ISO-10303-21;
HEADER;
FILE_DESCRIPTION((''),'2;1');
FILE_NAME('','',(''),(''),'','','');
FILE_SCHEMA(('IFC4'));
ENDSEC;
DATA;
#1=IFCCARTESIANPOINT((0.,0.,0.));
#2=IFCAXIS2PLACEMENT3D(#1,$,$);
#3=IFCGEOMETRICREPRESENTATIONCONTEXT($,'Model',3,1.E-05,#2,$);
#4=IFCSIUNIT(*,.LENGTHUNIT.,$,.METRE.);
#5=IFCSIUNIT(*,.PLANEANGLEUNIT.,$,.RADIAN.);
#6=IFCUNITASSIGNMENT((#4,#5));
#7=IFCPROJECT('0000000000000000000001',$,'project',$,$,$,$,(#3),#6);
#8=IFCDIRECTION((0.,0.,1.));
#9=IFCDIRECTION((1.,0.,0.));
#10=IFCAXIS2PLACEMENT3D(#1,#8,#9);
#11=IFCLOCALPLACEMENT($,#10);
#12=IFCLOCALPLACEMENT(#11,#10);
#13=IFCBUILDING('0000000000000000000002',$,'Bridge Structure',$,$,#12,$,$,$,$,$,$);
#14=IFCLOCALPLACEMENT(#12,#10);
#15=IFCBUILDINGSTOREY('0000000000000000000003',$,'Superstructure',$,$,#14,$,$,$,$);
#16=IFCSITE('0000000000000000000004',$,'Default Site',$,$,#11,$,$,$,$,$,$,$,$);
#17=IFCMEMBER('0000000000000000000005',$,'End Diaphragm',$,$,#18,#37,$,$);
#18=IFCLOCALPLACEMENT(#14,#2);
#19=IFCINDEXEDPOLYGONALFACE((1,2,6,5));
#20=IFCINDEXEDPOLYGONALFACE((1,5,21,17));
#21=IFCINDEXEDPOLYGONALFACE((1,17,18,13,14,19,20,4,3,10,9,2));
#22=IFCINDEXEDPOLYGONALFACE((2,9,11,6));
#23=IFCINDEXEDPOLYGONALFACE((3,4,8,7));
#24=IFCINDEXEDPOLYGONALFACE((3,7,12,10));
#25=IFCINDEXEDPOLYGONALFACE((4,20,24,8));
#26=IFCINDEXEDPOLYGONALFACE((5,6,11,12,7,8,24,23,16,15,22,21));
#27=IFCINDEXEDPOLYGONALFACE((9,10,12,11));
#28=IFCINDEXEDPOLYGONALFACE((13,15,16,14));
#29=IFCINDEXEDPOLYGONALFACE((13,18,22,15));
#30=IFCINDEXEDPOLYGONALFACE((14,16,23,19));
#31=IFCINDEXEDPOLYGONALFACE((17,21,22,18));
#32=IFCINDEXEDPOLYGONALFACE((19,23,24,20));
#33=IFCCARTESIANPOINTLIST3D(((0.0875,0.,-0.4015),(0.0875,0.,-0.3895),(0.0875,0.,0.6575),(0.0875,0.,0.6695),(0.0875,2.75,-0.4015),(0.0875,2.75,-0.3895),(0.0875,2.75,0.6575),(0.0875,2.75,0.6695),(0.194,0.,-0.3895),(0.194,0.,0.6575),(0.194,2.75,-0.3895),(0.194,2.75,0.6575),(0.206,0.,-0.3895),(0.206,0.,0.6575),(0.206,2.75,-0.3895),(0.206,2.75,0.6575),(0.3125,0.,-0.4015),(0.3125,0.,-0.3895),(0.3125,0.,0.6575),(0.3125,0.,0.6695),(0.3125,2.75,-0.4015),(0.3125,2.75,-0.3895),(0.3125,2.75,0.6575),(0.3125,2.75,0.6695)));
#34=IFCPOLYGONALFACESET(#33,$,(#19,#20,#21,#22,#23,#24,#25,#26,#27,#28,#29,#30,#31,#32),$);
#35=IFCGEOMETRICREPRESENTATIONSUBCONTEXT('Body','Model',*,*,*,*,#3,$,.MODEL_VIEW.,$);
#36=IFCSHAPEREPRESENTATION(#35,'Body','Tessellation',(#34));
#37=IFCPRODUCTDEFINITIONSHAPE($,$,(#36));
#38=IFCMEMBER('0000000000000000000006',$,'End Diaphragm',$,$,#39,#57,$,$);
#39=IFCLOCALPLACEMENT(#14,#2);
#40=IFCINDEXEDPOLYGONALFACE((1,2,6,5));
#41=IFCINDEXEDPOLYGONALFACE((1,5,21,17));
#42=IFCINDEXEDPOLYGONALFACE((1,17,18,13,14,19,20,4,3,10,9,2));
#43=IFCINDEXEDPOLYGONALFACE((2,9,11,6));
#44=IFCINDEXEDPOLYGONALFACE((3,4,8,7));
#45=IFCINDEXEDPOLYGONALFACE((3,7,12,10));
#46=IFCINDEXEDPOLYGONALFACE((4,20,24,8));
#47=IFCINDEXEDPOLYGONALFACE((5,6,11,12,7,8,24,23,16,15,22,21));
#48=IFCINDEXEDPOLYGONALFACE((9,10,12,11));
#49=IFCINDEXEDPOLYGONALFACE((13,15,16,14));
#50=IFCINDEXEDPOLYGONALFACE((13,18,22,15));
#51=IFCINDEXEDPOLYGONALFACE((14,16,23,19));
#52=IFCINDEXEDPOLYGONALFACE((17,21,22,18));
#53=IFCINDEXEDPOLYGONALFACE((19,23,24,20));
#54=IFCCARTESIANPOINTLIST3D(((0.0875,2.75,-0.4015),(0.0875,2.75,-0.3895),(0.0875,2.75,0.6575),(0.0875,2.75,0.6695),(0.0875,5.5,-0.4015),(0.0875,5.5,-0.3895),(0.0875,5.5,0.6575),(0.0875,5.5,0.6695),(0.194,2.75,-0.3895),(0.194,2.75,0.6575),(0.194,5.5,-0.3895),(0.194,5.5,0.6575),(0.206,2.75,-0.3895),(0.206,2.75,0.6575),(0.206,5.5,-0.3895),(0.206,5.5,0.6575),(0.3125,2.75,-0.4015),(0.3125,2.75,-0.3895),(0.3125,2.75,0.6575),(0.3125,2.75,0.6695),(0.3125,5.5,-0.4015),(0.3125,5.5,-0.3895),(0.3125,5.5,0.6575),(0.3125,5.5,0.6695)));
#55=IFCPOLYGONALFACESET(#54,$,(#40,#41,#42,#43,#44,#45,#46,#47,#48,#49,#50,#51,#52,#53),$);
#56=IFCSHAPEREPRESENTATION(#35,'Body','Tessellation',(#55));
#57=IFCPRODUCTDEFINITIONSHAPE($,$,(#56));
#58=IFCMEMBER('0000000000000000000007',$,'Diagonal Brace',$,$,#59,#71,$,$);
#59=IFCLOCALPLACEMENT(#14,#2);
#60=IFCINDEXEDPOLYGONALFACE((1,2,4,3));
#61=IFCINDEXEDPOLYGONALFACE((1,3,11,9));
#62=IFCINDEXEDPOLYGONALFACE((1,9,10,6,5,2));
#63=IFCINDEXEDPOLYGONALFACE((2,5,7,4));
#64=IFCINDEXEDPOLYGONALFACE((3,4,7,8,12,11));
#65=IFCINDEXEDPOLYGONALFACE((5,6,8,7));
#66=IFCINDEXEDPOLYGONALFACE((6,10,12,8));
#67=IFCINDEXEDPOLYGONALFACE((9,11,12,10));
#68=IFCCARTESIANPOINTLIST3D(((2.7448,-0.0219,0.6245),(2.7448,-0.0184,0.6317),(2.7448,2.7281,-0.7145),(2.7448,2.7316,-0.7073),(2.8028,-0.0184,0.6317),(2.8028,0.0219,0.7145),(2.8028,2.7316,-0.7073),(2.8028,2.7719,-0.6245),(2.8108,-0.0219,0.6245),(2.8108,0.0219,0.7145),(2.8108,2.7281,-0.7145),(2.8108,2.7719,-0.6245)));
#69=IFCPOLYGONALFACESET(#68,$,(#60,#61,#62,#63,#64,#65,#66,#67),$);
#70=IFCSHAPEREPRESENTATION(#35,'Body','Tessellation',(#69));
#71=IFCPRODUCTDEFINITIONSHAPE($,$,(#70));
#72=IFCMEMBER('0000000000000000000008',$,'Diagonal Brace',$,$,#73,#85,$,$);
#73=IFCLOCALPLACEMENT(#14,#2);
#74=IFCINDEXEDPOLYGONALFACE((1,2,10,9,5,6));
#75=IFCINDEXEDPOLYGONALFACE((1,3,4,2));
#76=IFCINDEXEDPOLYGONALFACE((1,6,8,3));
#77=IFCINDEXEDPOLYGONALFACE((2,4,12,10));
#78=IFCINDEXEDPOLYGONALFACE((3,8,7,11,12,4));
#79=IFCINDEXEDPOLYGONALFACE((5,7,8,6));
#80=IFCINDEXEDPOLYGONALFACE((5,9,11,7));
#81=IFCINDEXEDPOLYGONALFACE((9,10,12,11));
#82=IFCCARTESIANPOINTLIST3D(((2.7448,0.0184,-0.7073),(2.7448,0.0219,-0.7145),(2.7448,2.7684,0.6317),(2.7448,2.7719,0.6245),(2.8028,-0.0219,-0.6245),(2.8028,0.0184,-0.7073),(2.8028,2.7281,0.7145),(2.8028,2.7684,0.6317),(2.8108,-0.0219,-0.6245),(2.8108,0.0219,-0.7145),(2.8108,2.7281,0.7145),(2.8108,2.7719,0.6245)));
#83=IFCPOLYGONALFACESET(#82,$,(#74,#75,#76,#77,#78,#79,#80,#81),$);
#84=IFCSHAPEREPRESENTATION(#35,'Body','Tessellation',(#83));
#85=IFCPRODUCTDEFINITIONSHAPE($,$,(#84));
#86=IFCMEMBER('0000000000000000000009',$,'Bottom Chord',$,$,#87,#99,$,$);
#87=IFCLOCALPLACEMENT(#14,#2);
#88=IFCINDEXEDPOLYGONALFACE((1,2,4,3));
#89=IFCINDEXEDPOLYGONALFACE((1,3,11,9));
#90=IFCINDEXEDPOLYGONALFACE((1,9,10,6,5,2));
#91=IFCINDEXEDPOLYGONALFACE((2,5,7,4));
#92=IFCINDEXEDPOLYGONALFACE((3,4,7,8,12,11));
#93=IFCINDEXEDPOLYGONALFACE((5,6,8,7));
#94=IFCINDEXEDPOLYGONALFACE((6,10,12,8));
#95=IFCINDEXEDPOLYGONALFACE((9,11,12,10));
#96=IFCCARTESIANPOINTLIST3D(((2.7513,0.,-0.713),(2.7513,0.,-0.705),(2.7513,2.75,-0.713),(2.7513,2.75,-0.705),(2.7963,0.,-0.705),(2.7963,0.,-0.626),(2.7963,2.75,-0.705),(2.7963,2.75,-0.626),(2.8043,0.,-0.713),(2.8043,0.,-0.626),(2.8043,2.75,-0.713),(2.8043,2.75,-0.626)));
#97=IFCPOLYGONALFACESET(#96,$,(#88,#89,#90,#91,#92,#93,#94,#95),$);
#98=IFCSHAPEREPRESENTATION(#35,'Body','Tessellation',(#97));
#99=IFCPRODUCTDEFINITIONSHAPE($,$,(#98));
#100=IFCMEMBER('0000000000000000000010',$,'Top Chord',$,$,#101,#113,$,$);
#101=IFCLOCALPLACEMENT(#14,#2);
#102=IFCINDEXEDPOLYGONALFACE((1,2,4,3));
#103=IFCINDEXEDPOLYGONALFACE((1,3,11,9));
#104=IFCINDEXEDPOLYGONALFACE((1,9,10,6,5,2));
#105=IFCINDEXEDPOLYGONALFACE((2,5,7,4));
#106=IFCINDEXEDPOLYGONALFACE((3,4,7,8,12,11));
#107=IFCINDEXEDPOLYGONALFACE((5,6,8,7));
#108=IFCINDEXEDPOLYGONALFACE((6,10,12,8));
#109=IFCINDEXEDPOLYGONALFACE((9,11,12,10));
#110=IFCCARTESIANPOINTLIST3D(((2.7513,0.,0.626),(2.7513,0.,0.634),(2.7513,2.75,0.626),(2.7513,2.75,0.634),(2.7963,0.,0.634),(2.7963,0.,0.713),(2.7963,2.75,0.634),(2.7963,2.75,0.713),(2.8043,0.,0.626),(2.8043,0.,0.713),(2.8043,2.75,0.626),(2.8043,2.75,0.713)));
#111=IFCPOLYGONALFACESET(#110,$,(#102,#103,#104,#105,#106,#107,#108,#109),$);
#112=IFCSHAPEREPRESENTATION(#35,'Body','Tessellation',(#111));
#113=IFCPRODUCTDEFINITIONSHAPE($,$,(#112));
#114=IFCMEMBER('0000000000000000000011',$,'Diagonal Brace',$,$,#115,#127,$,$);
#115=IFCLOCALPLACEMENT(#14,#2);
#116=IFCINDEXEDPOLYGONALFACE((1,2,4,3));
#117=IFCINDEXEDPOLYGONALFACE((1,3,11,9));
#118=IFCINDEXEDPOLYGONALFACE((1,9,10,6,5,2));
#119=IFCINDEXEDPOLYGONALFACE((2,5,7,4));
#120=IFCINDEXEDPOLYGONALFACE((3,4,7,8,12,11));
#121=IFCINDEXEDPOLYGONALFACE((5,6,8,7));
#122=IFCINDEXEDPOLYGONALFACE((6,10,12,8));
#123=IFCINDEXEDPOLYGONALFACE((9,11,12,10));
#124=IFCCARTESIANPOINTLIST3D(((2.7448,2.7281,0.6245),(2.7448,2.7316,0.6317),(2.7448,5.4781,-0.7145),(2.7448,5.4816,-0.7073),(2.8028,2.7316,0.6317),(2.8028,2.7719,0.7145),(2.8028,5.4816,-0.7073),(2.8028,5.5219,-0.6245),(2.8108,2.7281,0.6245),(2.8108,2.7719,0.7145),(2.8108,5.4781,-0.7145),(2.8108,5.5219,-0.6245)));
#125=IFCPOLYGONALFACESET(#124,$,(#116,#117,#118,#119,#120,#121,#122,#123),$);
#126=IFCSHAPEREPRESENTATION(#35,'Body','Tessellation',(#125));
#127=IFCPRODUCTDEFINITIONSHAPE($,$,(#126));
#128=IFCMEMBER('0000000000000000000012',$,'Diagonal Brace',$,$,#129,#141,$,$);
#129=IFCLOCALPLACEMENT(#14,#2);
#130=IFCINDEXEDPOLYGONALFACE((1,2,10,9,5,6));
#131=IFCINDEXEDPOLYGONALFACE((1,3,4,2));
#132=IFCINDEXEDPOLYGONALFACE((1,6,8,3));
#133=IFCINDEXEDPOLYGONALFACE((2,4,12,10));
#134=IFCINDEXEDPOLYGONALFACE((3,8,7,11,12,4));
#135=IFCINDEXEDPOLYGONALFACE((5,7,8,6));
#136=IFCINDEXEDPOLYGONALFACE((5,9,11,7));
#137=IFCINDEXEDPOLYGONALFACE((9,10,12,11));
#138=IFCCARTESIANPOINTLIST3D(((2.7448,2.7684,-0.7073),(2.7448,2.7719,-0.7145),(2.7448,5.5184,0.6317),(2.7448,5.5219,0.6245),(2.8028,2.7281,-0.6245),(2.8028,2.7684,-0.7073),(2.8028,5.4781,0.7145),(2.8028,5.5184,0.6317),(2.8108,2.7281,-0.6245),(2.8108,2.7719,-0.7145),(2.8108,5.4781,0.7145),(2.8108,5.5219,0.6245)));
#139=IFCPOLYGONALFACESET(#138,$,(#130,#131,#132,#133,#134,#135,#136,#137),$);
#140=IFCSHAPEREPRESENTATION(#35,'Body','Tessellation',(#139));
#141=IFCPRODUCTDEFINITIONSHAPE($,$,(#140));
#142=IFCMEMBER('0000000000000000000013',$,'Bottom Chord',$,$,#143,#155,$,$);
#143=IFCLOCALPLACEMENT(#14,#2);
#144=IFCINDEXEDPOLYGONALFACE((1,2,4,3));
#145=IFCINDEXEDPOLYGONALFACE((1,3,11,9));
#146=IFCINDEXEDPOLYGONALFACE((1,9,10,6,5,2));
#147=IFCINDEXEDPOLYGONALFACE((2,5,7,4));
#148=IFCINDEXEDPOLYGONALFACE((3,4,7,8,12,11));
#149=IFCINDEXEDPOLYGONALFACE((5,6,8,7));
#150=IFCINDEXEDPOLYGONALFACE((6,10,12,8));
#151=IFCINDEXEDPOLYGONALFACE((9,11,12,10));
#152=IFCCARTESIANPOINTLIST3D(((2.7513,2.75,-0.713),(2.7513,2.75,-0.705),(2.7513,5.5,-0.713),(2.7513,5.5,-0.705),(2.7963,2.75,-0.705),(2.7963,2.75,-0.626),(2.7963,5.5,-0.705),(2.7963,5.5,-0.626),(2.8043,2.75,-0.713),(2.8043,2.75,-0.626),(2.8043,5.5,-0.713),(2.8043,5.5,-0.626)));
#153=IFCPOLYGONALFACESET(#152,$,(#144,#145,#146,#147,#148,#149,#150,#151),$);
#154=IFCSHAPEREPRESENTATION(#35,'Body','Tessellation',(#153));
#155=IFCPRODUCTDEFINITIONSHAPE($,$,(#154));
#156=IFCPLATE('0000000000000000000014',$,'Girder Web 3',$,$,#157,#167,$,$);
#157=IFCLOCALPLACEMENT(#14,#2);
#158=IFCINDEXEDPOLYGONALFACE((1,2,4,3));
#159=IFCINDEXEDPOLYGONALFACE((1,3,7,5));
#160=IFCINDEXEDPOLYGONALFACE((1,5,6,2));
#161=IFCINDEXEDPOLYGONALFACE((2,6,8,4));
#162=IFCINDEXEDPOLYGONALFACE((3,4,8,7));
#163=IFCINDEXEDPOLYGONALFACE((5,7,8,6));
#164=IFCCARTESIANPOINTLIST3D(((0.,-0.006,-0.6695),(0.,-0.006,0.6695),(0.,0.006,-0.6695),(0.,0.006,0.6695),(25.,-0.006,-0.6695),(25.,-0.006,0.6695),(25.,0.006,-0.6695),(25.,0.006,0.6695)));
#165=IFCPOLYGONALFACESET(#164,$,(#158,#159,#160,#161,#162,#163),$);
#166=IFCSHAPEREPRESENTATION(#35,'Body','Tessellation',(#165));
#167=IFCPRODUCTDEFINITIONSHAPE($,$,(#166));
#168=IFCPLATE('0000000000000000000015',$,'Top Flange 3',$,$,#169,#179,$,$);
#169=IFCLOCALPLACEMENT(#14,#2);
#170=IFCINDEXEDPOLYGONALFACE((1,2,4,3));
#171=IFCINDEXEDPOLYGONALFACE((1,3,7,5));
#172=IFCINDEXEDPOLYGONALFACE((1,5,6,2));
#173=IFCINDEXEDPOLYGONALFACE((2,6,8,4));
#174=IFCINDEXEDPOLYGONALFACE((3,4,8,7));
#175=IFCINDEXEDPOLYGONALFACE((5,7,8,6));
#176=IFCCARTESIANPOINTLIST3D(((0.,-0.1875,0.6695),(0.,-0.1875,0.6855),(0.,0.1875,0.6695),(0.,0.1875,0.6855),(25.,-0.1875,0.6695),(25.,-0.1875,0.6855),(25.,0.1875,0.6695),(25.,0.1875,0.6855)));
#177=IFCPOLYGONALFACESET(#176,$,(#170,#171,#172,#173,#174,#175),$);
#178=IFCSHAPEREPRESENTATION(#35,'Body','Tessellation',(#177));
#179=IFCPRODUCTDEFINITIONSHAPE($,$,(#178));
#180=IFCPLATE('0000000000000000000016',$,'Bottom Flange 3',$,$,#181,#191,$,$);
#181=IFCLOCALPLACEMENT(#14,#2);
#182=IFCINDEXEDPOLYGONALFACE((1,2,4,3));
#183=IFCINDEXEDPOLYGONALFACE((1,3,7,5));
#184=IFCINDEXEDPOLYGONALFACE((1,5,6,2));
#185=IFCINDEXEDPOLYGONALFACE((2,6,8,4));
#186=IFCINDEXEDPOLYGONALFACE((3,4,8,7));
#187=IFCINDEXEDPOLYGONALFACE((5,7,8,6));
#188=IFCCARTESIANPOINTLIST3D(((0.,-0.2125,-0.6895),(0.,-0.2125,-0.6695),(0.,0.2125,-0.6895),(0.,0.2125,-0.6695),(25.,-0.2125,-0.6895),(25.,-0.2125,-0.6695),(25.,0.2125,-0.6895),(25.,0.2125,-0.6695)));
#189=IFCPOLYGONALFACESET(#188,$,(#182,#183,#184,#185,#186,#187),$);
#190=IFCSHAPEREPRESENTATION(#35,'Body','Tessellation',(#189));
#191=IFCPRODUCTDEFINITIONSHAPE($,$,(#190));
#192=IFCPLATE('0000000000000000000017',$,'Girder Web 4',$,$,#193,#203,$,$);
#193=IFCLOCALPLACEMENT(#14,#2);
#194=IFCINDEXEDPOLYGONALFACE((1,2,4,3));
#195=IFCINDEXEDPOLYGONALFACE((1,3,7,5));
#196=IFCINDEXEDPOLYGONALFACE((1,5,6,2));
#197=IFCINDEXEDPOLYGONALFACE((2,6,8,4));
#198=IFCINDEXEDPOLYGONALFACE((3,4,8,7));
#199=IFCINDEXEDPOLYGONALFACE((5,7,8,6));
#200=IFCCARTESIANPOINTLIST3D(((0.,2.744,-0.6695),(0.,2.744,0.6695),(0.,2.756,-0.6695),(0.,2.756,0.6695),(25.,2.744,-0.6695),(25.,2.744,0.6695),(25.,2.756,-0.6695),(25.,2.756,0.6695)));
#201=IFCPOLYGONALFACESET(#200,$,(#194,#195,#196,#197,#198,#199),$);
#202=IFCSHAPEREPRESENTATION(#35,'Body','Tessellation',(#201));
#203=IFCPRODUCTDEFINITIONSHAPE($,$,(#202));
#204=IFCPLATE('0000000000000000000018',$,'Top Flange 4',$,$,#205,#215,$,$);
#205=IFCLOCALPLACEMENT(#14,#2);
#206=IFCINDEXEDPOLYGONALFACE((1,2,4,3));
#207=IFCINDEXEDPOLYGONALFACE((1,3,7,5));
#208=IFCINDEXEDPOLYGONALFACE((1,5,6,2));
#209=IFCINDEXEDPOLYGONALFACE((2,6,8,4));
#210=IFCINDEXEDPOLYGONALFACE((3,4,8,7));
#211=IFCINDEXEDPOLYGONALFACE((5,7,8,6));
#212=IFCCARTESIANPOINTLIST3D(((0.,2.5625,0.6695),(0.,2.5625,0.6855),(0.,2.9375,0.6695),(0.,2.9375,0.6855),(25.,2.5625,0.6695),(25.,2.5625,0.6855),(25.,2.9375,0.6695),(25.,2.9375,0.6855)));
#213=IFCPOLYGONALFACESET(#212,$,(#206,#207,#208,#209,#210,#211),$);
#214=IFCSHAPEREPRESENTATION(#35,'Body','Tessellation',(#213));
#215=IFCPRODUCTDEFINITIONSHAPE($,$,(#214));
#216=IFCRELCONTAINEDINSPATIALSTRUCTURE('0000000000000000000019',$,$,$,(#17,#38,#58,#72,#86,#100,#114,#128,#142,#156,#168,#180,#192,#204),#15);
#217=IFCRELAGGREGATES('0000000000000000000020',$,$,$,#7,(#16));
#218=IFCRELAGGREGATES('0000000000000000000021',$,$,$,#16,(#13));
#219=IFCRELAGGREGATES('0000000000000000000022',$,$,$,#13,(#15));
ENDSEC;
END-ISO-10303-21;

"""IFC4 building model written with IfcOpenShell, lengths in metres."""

from ifc_helpers import new_model, si_unit, frame, origin, origin_with_axes, origin_2d_with_axis, place, context, subcontext, project, spatial, rectangle, i_section, l_section, extrude, element, save


model = new_model("IFC4")

# Units and contexts
model_context = context("Model", 3, precision=1e-05, world=origin())
body_context = subcontext(model_context, "Body", "Model", "MODEL_VIEW")
ifc_project = project(units=[si_unit("LENGTHUNIT", "METRE"), si_unit("PLANEANGLEUNIT", "RADIAN")], contexts=[model_context])

# Site, building, storey
site_placement = place(None, origin_with_axes())
site = spatial("IfcSite", under=ifc_project, at=site_placement, Name="Default Site")
building_placement = place(site_placement, origin_with_axes())
building = spatial("IfcBuilding", under=site, at=building_placement, Name="Bridge Structure")
storey_placement = place(building_placement, origin_with_axes())
storey = spatial("IfcBuildingStorey", under=building, at=storey_placement, Name="Superstructure")

# Members
for number, where, z_axis, x_axis, name in (
    (1, (0.2, 0.0, 0.134), (0.0, 1.0, 0.0), (-1.0, 0.0, 0.0), "End Diaphragm"),
    (2, (0.2, 2.75, 0.134), (0.0, 1.0, 0.0), (-1.0, 0.0, 0.0), "End Diaphragm"),
):
    element("IfcMember", number, at=place(storey_placement, frame(where, z_axis=z_axis, x_axis=x_axis)), inside=storey, Name=name, context=body_context, shape_type="SweptSolid", body=[
        extrude(i_section(OverallWidth=0.225, OverallDepth=1.071, WebThickness=0.012, FlangeThickness=0.012, at=origin_2d_with_axis()), origin_with_axes(), (0.0, 0.0, 1.0), 2.75),
    ])
for number, where, z_axis, x_axis, name in (
    (3, (2.7778, 0.0, 0.6695), (0.0, 0.899086, -0.437773), (-1.0, 0.0, 0.0), "Diagonal Brace"),
    (4, (2.7778, 0.0, -0.6695), (0.0, 0.899086, 0.437773), (-1.0, 0.0, 0.0), "Diagonal Brace"),
):
    element("IfcMember", number, at=place(storey_placement, frame(where, z_axis=z_axis, x_axis=x_axis)), inside=storey, Name=name, context=body_context, shape_type="SweptSolid", body=[
        extrude(l_section(Depth=0.1, Width=0.066, Thickness=0.008, at=origin_2d_with_axis()), origin_with_axes(), (0.0, 0.0, 1.0), 3.0587),
    ])
for number, where, z_axis, x_axis, name in (
    (5, (2.7778, 0.0, -0.6695), (0.0, 1.0, 0.0), (-1.0, 0.0, 0.0), "Bottom Chord"),
    (6, (2.7778, 0.0, 0.6695), (0.0, 1.0, 0.0), (-1.0, 0.0, 0.0), "Top Chord"),
):
    element("IfcMember", number, at=place(storey_placement, frame(where, z_axis=z_axis, x_axis=x_axis)), inside=storey, Name=name, context=body_context, shape_type="SweptSolid", body=[
        extrude(l_section(Depth=0.087, Width=0.053, Thickness=0.008, at=origin_2d_with_axis()), origin_with_axes(), (0.0, 0.0, 1.0), 2.75),
    ])
for number, where, z_axis, x_axis, name in (
    (7, (2.7778, 2.75, 0.6695), (0.0, 0.899086, -0.437773), (-1.0, 0.0, 0.0), "Diagonal Brace"),
    (8, (2.7778, 2.75, -0.6695), (0.0, 0.899086, 0.437773), (-1.0, 0.0, 0.0), "Diagonal Brace"),
):
    element("IfcMember", number, at=place(storey_placement, frame(where, z_axis=z_axis, x_axis=x_axis)), inside=storey, Name=name, context=body_context, shape_type="SweptSolid", body=[
        extrude(l_section(Depth=0.1, Width=0.066, Thickness=0.008, at=origin_2d_with_axis()), origin_with_axes(), (0.0, 0.0, 1.0), 3.0587),
    ])
member_placement = place(storey_placement, frame((2.7778, 2.75, -0.6695), z_axis=(0.0, 1.0, 0.0), x_axis=(-1.0, 0.0, 0.0)))
element("IfcMember", 9, at=member_placement, inside=storey, Name="Bottom Chord", context=body_context, shape_type="SweptSolid", body=[
    extrude(l_section(Depth=0.087, Width=0.053, Thickness=0.008, at=origin_2d_with_axis()), origin_with_axes(), (0.0, 0.0, 1.0), 2.75),
])

# Plates
plate_1_placement = place(storey_placement, frame((0.0, 0.0, 0.0), z_axis=(1.0, 0.0, 0.0), x_axis=(0.0, 1.0, 0.0)))
element("IfcPlate", 10, at=plate_1_placement, inside=storey, Name="Girder Web 3", context=body_context, shape_type="SweptSolid", body=[
    extrude(rectangle(XDim=0.012, YDim=1.339, at=origin_2d_with_axis()), origin_with_axes(), (0.0, 0.0, 1.0), 25.0),
])
plate_2_placement = place(storey_placement, frame((0.0, 0.0, 0.6775), z_axis=(1.0, 0.0, 0.0), x_axis=(0.0, 1.0, 0.0)))
element("IfcPlate", 11, at=plate_2_placement, inside=storey, Name="Top Flange 3", context=body_context, shape_type="SweptSolid", body=[
    extrude(rectangle(XDim=0.375, YDim=0.016, at=origin_2d_with_axis()), origin_with_axes(), (0.0, 0.0, 1.0), 25.0),
])
plate_3_placement = place(storey_placement, frame((0.0, 0.0, -0.6795), z_axis=(1.0, 0.0, 0.0), x_axis=(0.0, 1.0, 0.0)))
element("IfcPlate", 12, at=plate_3_placement, inside=storey, Name="Bottom Flange 3", context=body_context, shape_type="SweptSolid", body=[
    extrude(rectangle(XDim=0.425, YDim=0.02, at=origin_2d_with_axis()), origin_with_axes(), (0.0, 0.0, 1.0), 25.0),
])
plate_4_placement = place(storey_placement, frame((0.0, 2.75, 0.0), z_axis=(1.0, 0.0, 0.0), x_axis=(0.0, 1.0, 0.0)))
element("IfcPlate", 13, at=plate_4_placement, inside=storey, Name="Girder Web 4", context=body_context, shape_type="SweptSolid", body=[
    extrude(rectangle(XDim=0.012, YDim=1.339, at=origin_2d_with_axis()), origin_with_axes(), (0.0, 0.0, 1.0), 25.0),
])
plate_5_placement = place(storey_placement, frame((0.0, 2.75, 0.6775), z_axis=(1.0, 0.0, 0.0), x_axis=(0.0, 1.0, 0.0)))
element("IfcPlate", 14, at=plate_5_placement, inside=storey, Name="Top Flange 4", context=body_context, shape_type="SweptSolid", body=[
    extrude(rectangle(XDim=0.375, YDim=0.016, at=origin_2d_with_axis()), origin_with_axes(), (0.0, 0.0, 1.0), 25.0),
])

save(model, "model.ifc")
